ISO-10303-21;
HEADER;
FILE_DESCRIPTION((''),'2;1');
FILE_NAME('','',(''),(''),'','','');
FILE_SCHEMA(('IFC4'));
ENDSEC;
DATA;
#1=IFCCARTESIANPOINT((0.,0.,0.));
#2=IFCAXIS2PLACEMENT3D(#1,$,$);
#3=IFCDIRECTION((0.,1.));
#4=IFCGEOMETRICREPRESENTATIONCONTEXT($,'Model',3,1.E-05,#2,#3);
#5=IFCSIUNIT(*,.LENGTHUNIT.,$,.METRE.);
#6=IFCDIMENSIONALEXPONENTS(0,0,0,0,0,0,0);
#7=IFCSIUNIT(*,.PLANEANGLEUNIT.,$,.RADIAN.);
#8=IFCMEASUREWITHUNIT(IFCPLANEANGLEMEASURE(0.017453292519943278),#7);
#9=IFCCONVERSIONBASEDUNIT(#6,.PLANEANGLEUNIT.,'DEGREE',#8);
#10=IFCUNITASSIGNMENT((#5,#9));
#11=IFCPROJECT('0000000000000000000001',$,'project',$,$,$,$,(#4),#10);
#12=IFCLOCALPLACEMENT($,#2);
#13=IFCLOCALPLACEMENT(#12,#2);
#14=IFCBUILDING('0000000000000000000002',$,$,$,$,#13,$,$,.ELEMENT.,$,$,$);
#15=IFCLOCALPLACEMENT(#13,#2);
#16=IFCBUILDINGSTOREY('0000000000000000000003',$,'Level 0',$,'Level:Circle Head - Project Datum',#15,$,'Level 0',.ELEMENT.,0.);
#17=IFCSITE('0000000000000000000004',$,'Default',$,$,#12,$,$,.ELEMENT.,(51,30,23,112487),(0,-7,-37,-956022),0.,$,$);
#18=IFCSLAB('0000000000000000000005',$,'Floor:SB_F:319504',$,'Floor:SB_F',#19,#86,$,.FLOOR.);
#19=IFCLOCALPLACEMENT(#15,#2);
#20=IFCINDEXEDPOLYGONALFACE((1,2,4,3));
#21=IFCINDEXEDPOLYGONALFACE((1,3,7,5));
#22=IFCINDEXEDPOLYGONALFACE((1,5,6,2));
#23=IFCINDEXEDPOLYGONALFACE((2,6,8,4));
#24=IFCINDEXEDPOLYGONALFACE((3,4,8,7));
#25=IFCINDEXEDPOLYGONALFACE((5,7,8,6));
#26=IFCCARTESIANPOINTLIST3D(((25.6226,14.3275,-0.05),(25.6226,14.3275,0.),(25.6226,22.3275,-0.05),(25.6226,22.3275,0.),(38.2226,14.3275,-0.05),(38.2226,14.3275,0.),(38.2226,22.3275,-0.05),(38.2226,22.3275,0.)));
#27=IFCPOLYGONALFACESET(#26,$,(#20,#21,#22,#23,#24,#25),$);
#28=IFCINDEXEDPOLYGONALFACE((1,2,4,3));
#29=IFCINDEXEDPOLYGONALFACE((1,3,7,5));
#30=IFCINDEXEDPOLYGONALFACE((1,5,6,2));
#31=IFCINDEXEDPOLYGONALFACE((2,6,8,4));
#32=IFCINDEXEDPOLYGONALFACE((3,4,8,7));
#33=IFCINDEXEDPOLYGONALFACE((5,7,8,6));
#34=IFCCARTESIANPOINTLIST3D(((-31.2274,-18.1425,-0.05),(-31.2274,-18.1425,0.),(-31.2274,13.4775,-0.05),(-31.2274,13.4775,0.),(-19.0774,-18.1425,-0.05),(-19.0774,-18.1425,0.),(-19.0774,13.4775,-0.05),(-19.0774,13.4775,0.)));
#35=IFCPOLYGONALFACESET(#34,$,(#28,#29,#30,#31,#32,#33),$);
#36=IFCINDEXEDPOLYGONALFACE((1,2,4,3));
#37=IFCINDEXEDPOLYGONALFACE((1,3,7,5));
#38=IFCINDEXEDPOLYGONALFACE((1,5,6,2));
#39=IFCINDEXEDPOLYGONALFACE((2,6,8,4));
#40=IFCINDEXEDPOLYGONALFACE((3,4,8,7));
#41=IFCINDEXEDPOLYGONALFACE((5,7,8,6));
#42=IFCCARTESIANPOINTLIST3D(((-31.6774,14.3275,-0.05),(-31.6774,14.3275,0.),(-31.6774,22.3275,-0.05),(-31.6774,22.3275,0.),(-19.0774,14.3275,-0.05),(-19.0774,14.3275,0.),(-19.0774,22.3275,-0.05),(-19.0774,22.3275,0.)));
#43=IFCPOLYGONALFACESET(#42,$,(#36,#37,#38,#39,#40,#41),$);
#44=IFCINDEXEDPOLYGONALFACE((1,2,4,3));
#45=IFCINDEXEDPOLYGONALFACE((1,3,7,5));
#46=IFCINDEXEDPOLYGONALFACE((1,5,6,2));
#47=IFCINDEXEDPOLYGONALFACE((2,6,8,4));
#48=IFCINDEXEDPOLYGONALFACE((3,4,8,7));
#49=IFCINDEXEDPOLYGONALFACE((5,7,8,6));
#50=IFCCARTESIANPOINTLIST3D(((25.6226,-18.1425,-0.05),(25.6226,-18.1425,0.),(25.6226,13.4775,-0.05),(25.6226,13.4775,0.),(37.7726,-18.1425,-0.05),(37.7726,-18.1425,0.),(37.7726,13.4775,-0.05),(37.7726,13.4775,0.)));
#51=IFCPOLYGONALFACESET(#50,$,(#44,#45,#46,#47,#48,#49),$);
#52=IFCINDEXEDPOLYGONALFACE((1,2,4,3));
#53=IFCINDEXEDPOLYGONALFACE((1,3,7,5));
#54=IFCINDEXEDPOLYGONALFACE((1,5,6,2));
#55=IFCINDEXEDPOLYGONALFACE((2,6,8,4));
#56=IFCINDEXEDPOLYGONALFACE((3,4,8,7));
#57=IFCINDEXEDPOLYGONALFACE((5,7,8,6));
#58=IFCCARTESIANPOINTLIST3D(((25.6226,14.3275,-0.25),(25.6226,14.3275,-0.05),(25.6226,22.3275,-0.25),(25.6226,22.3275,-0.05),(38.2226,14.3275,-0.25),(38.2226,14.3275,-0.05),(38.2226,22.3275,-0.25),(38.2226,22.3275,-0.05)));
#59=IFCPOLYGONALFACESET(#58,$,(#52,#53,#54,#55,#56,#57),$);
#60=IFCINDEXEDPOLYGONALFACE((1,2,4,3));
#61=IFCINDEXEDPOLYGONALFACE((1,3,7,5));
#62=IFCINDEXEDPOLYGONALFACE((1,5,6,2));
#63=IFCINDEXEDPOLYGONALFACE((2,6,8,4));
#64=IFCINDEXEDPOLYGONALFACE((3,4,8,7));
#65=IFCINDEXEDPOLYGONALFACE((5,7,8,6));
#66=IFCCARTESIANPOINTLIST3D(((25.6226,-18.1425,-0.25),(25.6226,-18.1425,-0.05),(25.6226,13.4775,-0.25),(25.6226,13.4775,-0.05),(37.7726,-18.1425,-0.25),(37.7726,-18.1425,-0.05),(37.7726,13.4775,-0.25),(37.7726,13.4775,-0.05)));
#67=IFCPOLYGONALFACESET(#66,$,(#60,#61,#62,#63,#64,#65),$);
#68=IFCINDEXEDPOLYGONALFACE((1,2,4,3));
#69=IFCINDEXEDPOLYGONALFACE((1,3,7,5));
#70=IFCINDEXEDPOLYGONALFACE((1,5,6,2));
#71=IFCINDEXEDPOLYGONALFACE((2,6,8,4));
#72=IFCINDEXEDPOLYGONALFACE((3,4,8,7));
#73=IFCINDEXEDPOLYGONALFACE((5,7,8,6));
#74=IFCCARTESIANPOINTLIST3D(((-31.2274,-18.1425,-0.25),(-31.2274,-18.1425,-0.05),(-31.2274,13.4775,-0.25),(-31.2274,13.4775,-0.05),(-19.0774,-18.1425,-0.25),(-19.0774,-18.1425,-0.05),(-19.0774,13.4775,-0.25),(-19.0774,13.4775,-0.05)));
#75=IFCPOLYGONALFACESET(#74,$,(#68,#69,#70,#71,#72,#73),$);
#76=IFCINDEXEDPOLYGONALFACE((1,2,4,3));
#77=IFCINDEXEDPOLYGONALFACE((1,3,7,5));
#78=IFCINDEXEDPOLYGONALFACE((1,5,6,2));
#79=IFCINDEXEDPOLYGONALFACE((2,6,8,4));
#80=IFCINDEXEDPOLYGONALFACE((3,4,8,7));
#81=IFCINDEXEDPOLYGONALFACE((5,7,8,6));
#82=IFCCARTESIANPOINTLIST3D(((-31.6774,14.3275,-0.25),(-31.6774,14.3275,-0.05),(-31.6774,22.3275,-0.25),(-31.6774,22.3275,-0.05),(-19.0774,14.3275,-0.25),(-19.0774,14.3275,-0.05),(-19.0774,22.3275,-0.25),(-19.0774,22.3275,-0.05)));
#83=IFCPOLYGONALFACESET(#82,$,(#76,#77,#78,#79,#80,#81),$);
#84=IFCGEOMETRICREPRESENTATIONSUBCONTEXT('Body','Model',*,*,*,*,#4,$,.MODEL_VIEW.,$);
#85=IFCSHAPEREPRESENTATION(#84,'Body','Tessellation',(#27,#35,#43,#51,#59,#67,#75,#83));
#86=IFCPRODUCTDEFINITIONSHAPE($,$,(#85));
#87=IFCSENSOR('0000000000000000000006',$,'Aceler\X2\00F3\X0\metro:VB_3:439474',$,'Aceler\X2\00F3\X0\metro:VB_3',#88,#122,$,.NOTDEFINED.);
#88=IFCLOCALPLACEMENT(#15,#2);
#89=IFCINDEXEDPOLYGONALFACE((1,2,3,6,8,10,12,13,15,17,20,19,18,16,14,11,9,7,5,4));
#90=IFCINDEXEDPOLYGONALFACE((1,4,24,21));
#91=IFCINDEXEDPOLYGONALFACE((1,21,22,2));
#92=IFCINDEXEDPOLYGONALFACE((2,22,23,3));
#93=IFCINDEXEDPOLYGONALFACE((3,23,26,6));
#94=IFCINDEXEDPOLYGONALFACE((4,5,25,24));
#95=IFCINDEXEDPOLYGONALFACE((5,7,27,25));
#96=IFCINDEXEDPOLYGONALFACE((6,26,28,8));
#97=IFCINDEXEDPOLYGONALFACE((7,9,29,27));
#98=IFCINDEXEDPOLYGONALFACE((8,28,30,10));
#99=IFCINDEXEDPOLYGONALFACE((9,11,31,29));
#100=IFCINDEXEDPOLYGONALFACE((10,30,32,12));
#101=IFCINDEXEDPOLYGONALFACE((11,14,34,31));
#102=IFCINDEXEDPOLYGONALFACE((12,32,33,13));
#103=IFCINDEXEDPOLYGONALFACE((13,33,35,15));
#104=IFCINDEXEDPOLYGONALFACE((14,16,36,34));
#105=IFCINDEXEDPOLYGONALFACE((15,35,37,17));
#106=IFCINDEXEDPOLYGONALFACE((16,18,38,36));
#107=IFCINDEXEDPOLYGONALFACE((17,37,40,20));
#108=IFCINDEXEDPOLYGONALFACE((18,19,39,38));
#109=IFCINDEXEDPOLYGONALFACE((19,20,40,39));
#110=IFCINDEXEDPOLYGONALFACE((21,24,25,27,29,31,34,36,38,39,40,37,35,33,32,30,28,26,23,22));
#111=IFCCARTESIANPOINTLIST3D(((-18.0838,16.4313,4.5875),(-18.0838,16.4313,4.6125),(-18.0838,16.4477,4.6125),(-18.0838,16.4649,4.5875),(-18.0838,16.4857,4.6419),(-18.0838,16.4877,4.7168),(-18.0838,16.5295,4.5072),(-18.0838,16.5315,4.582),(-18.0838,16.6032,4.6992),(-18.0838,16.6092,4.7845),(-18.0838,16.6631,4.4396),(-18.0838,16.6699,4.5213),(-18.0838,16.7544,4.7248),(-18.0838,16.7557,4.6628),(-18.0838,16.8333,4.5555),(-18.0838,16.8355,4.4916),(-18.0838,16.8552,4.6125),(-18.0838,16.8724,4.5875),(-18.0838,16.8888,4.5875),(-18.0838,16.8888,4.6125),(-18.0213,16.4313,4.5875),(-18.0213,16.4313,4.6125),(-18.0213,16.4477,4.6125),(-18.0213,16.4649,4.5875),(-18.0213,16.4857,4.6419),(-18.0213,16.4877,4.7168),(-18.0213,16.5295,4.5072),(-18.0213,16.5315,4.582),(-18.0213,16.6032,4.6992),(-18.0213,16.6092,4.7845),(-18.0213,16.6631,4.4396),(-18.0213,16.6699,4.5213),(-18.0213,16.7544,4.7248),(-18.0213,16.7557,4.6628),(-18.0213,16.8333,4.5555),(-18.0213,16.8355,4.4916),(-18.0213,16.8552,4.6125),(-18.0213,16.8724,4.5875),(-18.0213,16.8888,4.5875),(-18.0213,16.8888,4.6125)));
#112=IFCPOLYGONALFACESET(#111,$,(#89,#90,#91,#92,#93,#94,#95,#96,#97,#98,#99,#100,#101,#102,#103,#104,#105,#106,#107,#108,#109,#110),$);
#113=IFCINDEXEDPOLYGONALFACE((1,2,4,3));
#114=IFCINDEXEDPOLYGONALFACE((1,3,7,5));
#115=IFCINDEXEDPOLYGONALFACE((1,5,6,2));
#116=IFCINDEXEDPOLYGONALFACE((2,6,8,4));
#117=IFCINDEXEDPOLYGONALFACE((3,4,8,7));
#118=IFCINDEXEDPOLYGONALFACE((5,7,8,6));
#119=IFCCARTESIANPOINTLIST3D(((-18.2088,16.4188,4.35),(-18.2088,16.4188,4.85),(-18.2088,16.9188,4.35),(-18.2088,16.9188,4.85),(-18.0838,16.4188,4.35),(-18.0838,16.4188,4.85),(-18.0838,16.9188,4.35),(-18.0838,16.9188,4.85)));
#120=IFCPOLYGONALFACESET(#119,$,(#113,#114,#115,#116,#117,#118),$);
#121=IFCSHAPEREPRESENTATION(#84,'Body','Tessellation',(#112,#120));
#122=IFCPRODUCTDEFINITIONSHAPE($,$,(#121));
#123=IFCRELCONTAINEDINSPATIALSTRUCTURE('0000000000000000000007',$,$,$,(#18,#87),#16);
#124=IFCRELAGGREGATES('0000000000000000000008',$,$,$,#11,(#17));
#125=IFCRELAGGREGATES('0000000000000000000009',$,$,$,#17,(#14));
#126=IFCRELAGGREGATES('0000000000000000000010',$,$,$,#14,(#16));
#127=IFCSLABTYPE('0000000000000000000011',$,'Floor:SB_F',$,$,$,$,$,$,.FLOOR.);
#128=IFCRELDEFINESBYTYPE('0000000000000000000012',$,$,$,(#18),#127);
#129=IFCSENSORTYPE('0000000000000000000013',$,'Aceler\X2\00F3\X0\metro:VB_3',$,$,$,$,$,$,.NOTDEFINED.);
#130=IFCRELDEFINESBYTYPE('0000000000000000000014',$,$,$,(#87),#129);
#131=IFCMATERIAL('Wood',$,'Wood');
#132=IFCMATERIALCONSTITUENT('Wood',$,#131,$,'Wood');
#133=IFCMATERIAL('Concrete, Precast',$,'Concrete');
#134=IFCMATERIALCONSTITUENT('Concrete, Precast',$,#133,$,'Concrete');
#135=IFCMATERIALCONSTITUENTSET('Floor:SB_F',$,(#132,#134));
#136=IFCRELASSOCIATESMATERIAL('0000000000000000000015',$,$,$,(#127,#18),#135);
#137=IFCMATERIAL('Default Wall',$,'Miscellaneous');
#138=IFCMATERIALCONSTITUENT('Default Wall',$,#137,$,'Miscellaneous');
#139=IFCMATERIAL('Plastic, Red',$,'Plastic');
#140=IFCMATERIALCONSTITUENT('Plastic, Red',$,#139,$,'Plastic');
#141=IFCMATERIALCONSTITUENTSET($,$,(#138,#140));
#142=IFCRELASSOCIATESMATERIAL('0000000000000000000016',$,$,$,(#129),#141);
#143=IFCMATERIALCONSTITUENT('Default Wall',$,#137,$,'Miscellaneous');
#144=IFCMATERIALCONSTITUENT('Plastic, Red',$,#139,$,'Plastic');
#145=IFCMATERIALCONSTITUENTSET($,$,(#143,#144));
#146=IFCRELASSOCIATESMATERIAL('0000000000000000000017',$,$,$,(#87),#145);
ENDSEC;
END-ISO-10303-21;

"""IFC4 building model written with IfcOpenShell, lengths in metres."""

from ifc_helpers import new_model, entity, si_unit, converted_unit, direction, frame, origin, place, context, subcontext, project, spatial, indexed_curve, outline, extrude, source, transform, mapped, material, constituent, constituent_set, type_object, type_shapes, element, save


model = new_model("IFC4")

# Units and contexts
model_context = context("Model", 3, precision=1e-05, world=origin(), true_north=direction((0.0, 1.0)))
body_context = subcontext(model_context, "Body", "Model", "MODEL_VIEW")
ifc_project = project(units=[si_unit("LENGTHUNIT", "METRE"), converted_unit("PLANEANGLEUNIT", "DEGREE", entity("IfcPlaneAngleMeasure", 0.017453292519943278), si_unit("PLANEANGLEUNIT", "RADIAN"), dimensions=[0, 0, 0, 0, 0, 0, 0])], contexts=[model_context])

# Site, building, storey
site_placement = place(None, origin())
site = spatial("IfcSite", under=ifc_project, at=site_placement, Name="Default", CompositionType="ELEMENT", RefLatitude=(51, 30, 23, 112487), RefLongitude=(0, -7, -37, -956022), RefElevation=0.0)
building_placement = place(site_placement, origin())
building = spatial("IfcBuilding", under=site, at=building_placement, CompositionType="ELEMENT")
storey_placement = place(building_placement, origin())
storey = spatial("IfcBuildingStorey", under=building, at=storey_placement, Name="Level 0", ObjectType="Level:Circle Head - Project Datum", LongName="Level 0", CompositionType="ELEMENT", Elevation=0.0)

# Slab
ifc_material_1 = material(Name="Wood", Category="Wood")
ifc_constituent_1 = constituent(ifc_material_1, Name="Wood", Category="Wood")
ifc_material_2 = material(Name="Concrete, Precast", Category="Concrete")
ifc_constituent_2 = constituent(ifc_material_2, Name="Concrete, Precast", Category="Concrete")
ifc_constituent_set_1 = constituent_set(constituents=[ifc_constituent_1, ifc_constituent_2], Name="Floor:SB_F")
slab_type = type_object("IfcSlabType", Name="Floor:SB_F", PredefinedType="FLOOR", material=ifc_constituent_set_1)
slab_placement = place(storey_placement, origin())
element("IfcSlab", 1, at=slab_placement, inside=storey, type_object=slab_type, material=ifc_constituent_set_1, Name="Floor:SB_F:319504", ObjectType="Floor:SB_F", PredefinedType="FLOOR", context=body_context, shape_type="SweptSolid", body=[
    extrude(outline(indexed_curve([(-6.3, -4.0), (6.3, -4.0), (6.3, 4.0), (-6.3, 4.0), (-6.3, -4.0)], self_intersect=False)), frame((31.9226, 18.3275, -0.05), z_axis=(0.0, 0.0, 1.0), x_axis=(-1.0, 0.0, 0.0)), (0.0, 0.0, 1.0), 0.05),
    extrude(outline(indexed_curve([(-6.075, -15.81), (6.075, -15.81), (6.075, 15.81), (-6.075, 15.81), (-6.075, -15.81)], self_intersect=False)), frame((-25.1524, -2.3325, -0.05), z_axis=(0.0, 0.0, 1.0), x_axis=(-1.0, 0.0, 0.0)), (0.0, 0.0, 1.0), 0.05),
    extrude(outline(indexed_curve([(-6.3, -4.0), (6.3, -4.0), (6.3, 4.0), (-6.3, 4.0), (-6.3, -4.0)], self_intersect=False)), frame((-25.3774, 18.3275, -0.05), z_axis=(0.0, 0.0, 1.0), x_axis=(-1.0, 0.0, 0.0)), (0.0, 0.0, 1.0), 0.05),
    extrude(outline(indexed_curve([(-6.075, -15.81), (6.075, -15.81), (6.075, 15.81), (-6.075, 15.81), (-6.075, -15.81)], self_intersect=False)), frame((31.6976, -2.3325, -0.05), z_axis=(0.0, 0.0, 1.0), x_axis=(-1.0, 0.0, 0.0)), (0.0, 0.0, 1.0), 0.05),
    extrude(outline(indexed_curve([(-6.3, -4.0), (6.3, -4.0), (6.3, 4.0), (-6.3, 4.0), (-6.3, -4.0)], self_intersect=False)), frame((31.9226, 18.3275, -0.25), z_axis=(0.0, 0.0, 1.0), x_axis=(-1.0, 0.0, 0.0)), (0.0, 0.0, 1.0), 0.2),
    extrude(outline(indexed_curve([(-6.075, -15.81), (6.075, -15.81), (6.075, 15.81), (-6.075, 15.81), (-6.075, -15.81)], self_intersect=False)), frame((31.6976, -2.3325, -0.25), z_axis=(0.0, 0.0, 1.0), x_axis=(-1.0, 0.0, 0.0)), (0.0, 0.0, 1.0), 0.2),
    extrude(outline(indexed_curve([(-6.075, -15.81), (6.075, -15.81), (6.075, 15.81), (-6.075, 15.81), (-6.075, -15.81)], self_intersect=False)), frame((-25.1524, -2.3325, -0.25), z_axis=(0.0, 0.0, 1.0), x_axis=(-1.0, 0.0, 0.0)), (0.0, 0.0, 1.0), 0.2),
    extrude(outline(indexed_curve([(-6.3, -4.0), (6.3, -4.0), (6.3, 4.0), (-6.3, 4.0), (-6.3, -4.0)], self_intersect=False)), frame((-25.3774, 18.3275, -0.25), z_axis=(0.0, 0.0, 1.0), x_axis=(-1.0, 0.0, 0.0)), (0.0, 0.0, 1.0), 0.2),
])

# Sensor
ifc_material_3 = material(Name="Default Wall", Category="Miscellaneous")
ifc_constituent_3 = constituent(ifc_material_3, Name="Default Wall", Category="Miscellaneous")
ifc_material_4 = material(Name="Plastic, Red", Category="Plastic")
ifc_constituent_4 = constituent(ifc_material_4, Name="Plastic, Red", Category="Plastic")
ifc_constituent_set_2 = constituent_set(constituents=[ifc_constituent_3, ifc_constituent_4])
ifc_constituent_5 = constituent(ifc_material_3, Name="Default Wall", Category="Miscellaneous")
ifc_constituent_6 = constituent(ifc_material_4, Name="Plastic, Red", Category="Plastic")
ifc_constituent_set_3 = constituent_set(constituents=[ifc_constituent_5, ifc_constituent_6])
sensor_type_1 = type_object("IfcSensorType", Name="Acelerómetro:VB_3", PredefinedType="NOTDEFINED", material=ifc_constituent_set_3)
shared_shape_1 = source(origin(), body_context, "Body", "SweptSolid", [
    extrude(outline(indexed_curve([(-0.0675, -0.1929), (0.0442, -0.1929), (-0.0659, -0.1038), (0.1509, -0.1038), (-0.073, 0.0473), (0.1473, 0.0532), (0.0176, 0.1875), (0.0786, 0.1875), (0.0906, 0.2189), (0.0673, 0.2278), (0.0614, 0.2125), (-0.0413, 0.2125), (0.0899, 0.0767), (-0.1517, 0.0702), (0.0692, -0.0788), (-0.1365, -0.0788), (-0.0264, -0.1679), (-0.0847, -0.1679), (-0.0967, -0.1993), (-0.0734, -0.2082), (-0.0675, -0.1929)], self_intersect=False)), frame((-0.0168, -0.125, 0.2564), z_axis=(0.0, 1.0, 0.0), x_axis=(0.358368, 0.0, 0.93358)), (0.0, 0.0, 1.0), 0.0625),
    extrude(outline(indexed_curve([(-0.25, -0.0625), (0.25, -0.0625), (0.25, 0.0625), (-0.25, 0.0625), (-0.25, -0.0625)], self_intersect=False)), frame((0.0, 0.0, 0.0), z_axis=(0.0, 0.0, 1.0), x_axis=(-1.0, 0.0, 0.0)), (0.0, 0.0, 1.0), 0.5),
])
type_shapes(sensor_type_1, [shared_shape_1])
sensor_1_placement = place(storey_placement, frame((-18.1463, 16.6688, 4.35), z_axis=(0.0, 0.0, 1.0), x_axis=(0.0, 1.0, 0.0)))
element("IfcSensor", 2, at=sensor_1_placement, inside=storey, type_object=sensor_type_1, material=ifc_constituent_set_2, Name="Acelerómetro:VB_3:439474", ObjectType="Acelerómetro:VB_3", PredefinedType="NOTDEFINED", context=body_context, shape_type="MappedRepresentation", body=[
    mapped(shared_shape_1, transform((0.0, 0.0, 0.0), scale=1.0)),
])

save(model, "model.ifc")
